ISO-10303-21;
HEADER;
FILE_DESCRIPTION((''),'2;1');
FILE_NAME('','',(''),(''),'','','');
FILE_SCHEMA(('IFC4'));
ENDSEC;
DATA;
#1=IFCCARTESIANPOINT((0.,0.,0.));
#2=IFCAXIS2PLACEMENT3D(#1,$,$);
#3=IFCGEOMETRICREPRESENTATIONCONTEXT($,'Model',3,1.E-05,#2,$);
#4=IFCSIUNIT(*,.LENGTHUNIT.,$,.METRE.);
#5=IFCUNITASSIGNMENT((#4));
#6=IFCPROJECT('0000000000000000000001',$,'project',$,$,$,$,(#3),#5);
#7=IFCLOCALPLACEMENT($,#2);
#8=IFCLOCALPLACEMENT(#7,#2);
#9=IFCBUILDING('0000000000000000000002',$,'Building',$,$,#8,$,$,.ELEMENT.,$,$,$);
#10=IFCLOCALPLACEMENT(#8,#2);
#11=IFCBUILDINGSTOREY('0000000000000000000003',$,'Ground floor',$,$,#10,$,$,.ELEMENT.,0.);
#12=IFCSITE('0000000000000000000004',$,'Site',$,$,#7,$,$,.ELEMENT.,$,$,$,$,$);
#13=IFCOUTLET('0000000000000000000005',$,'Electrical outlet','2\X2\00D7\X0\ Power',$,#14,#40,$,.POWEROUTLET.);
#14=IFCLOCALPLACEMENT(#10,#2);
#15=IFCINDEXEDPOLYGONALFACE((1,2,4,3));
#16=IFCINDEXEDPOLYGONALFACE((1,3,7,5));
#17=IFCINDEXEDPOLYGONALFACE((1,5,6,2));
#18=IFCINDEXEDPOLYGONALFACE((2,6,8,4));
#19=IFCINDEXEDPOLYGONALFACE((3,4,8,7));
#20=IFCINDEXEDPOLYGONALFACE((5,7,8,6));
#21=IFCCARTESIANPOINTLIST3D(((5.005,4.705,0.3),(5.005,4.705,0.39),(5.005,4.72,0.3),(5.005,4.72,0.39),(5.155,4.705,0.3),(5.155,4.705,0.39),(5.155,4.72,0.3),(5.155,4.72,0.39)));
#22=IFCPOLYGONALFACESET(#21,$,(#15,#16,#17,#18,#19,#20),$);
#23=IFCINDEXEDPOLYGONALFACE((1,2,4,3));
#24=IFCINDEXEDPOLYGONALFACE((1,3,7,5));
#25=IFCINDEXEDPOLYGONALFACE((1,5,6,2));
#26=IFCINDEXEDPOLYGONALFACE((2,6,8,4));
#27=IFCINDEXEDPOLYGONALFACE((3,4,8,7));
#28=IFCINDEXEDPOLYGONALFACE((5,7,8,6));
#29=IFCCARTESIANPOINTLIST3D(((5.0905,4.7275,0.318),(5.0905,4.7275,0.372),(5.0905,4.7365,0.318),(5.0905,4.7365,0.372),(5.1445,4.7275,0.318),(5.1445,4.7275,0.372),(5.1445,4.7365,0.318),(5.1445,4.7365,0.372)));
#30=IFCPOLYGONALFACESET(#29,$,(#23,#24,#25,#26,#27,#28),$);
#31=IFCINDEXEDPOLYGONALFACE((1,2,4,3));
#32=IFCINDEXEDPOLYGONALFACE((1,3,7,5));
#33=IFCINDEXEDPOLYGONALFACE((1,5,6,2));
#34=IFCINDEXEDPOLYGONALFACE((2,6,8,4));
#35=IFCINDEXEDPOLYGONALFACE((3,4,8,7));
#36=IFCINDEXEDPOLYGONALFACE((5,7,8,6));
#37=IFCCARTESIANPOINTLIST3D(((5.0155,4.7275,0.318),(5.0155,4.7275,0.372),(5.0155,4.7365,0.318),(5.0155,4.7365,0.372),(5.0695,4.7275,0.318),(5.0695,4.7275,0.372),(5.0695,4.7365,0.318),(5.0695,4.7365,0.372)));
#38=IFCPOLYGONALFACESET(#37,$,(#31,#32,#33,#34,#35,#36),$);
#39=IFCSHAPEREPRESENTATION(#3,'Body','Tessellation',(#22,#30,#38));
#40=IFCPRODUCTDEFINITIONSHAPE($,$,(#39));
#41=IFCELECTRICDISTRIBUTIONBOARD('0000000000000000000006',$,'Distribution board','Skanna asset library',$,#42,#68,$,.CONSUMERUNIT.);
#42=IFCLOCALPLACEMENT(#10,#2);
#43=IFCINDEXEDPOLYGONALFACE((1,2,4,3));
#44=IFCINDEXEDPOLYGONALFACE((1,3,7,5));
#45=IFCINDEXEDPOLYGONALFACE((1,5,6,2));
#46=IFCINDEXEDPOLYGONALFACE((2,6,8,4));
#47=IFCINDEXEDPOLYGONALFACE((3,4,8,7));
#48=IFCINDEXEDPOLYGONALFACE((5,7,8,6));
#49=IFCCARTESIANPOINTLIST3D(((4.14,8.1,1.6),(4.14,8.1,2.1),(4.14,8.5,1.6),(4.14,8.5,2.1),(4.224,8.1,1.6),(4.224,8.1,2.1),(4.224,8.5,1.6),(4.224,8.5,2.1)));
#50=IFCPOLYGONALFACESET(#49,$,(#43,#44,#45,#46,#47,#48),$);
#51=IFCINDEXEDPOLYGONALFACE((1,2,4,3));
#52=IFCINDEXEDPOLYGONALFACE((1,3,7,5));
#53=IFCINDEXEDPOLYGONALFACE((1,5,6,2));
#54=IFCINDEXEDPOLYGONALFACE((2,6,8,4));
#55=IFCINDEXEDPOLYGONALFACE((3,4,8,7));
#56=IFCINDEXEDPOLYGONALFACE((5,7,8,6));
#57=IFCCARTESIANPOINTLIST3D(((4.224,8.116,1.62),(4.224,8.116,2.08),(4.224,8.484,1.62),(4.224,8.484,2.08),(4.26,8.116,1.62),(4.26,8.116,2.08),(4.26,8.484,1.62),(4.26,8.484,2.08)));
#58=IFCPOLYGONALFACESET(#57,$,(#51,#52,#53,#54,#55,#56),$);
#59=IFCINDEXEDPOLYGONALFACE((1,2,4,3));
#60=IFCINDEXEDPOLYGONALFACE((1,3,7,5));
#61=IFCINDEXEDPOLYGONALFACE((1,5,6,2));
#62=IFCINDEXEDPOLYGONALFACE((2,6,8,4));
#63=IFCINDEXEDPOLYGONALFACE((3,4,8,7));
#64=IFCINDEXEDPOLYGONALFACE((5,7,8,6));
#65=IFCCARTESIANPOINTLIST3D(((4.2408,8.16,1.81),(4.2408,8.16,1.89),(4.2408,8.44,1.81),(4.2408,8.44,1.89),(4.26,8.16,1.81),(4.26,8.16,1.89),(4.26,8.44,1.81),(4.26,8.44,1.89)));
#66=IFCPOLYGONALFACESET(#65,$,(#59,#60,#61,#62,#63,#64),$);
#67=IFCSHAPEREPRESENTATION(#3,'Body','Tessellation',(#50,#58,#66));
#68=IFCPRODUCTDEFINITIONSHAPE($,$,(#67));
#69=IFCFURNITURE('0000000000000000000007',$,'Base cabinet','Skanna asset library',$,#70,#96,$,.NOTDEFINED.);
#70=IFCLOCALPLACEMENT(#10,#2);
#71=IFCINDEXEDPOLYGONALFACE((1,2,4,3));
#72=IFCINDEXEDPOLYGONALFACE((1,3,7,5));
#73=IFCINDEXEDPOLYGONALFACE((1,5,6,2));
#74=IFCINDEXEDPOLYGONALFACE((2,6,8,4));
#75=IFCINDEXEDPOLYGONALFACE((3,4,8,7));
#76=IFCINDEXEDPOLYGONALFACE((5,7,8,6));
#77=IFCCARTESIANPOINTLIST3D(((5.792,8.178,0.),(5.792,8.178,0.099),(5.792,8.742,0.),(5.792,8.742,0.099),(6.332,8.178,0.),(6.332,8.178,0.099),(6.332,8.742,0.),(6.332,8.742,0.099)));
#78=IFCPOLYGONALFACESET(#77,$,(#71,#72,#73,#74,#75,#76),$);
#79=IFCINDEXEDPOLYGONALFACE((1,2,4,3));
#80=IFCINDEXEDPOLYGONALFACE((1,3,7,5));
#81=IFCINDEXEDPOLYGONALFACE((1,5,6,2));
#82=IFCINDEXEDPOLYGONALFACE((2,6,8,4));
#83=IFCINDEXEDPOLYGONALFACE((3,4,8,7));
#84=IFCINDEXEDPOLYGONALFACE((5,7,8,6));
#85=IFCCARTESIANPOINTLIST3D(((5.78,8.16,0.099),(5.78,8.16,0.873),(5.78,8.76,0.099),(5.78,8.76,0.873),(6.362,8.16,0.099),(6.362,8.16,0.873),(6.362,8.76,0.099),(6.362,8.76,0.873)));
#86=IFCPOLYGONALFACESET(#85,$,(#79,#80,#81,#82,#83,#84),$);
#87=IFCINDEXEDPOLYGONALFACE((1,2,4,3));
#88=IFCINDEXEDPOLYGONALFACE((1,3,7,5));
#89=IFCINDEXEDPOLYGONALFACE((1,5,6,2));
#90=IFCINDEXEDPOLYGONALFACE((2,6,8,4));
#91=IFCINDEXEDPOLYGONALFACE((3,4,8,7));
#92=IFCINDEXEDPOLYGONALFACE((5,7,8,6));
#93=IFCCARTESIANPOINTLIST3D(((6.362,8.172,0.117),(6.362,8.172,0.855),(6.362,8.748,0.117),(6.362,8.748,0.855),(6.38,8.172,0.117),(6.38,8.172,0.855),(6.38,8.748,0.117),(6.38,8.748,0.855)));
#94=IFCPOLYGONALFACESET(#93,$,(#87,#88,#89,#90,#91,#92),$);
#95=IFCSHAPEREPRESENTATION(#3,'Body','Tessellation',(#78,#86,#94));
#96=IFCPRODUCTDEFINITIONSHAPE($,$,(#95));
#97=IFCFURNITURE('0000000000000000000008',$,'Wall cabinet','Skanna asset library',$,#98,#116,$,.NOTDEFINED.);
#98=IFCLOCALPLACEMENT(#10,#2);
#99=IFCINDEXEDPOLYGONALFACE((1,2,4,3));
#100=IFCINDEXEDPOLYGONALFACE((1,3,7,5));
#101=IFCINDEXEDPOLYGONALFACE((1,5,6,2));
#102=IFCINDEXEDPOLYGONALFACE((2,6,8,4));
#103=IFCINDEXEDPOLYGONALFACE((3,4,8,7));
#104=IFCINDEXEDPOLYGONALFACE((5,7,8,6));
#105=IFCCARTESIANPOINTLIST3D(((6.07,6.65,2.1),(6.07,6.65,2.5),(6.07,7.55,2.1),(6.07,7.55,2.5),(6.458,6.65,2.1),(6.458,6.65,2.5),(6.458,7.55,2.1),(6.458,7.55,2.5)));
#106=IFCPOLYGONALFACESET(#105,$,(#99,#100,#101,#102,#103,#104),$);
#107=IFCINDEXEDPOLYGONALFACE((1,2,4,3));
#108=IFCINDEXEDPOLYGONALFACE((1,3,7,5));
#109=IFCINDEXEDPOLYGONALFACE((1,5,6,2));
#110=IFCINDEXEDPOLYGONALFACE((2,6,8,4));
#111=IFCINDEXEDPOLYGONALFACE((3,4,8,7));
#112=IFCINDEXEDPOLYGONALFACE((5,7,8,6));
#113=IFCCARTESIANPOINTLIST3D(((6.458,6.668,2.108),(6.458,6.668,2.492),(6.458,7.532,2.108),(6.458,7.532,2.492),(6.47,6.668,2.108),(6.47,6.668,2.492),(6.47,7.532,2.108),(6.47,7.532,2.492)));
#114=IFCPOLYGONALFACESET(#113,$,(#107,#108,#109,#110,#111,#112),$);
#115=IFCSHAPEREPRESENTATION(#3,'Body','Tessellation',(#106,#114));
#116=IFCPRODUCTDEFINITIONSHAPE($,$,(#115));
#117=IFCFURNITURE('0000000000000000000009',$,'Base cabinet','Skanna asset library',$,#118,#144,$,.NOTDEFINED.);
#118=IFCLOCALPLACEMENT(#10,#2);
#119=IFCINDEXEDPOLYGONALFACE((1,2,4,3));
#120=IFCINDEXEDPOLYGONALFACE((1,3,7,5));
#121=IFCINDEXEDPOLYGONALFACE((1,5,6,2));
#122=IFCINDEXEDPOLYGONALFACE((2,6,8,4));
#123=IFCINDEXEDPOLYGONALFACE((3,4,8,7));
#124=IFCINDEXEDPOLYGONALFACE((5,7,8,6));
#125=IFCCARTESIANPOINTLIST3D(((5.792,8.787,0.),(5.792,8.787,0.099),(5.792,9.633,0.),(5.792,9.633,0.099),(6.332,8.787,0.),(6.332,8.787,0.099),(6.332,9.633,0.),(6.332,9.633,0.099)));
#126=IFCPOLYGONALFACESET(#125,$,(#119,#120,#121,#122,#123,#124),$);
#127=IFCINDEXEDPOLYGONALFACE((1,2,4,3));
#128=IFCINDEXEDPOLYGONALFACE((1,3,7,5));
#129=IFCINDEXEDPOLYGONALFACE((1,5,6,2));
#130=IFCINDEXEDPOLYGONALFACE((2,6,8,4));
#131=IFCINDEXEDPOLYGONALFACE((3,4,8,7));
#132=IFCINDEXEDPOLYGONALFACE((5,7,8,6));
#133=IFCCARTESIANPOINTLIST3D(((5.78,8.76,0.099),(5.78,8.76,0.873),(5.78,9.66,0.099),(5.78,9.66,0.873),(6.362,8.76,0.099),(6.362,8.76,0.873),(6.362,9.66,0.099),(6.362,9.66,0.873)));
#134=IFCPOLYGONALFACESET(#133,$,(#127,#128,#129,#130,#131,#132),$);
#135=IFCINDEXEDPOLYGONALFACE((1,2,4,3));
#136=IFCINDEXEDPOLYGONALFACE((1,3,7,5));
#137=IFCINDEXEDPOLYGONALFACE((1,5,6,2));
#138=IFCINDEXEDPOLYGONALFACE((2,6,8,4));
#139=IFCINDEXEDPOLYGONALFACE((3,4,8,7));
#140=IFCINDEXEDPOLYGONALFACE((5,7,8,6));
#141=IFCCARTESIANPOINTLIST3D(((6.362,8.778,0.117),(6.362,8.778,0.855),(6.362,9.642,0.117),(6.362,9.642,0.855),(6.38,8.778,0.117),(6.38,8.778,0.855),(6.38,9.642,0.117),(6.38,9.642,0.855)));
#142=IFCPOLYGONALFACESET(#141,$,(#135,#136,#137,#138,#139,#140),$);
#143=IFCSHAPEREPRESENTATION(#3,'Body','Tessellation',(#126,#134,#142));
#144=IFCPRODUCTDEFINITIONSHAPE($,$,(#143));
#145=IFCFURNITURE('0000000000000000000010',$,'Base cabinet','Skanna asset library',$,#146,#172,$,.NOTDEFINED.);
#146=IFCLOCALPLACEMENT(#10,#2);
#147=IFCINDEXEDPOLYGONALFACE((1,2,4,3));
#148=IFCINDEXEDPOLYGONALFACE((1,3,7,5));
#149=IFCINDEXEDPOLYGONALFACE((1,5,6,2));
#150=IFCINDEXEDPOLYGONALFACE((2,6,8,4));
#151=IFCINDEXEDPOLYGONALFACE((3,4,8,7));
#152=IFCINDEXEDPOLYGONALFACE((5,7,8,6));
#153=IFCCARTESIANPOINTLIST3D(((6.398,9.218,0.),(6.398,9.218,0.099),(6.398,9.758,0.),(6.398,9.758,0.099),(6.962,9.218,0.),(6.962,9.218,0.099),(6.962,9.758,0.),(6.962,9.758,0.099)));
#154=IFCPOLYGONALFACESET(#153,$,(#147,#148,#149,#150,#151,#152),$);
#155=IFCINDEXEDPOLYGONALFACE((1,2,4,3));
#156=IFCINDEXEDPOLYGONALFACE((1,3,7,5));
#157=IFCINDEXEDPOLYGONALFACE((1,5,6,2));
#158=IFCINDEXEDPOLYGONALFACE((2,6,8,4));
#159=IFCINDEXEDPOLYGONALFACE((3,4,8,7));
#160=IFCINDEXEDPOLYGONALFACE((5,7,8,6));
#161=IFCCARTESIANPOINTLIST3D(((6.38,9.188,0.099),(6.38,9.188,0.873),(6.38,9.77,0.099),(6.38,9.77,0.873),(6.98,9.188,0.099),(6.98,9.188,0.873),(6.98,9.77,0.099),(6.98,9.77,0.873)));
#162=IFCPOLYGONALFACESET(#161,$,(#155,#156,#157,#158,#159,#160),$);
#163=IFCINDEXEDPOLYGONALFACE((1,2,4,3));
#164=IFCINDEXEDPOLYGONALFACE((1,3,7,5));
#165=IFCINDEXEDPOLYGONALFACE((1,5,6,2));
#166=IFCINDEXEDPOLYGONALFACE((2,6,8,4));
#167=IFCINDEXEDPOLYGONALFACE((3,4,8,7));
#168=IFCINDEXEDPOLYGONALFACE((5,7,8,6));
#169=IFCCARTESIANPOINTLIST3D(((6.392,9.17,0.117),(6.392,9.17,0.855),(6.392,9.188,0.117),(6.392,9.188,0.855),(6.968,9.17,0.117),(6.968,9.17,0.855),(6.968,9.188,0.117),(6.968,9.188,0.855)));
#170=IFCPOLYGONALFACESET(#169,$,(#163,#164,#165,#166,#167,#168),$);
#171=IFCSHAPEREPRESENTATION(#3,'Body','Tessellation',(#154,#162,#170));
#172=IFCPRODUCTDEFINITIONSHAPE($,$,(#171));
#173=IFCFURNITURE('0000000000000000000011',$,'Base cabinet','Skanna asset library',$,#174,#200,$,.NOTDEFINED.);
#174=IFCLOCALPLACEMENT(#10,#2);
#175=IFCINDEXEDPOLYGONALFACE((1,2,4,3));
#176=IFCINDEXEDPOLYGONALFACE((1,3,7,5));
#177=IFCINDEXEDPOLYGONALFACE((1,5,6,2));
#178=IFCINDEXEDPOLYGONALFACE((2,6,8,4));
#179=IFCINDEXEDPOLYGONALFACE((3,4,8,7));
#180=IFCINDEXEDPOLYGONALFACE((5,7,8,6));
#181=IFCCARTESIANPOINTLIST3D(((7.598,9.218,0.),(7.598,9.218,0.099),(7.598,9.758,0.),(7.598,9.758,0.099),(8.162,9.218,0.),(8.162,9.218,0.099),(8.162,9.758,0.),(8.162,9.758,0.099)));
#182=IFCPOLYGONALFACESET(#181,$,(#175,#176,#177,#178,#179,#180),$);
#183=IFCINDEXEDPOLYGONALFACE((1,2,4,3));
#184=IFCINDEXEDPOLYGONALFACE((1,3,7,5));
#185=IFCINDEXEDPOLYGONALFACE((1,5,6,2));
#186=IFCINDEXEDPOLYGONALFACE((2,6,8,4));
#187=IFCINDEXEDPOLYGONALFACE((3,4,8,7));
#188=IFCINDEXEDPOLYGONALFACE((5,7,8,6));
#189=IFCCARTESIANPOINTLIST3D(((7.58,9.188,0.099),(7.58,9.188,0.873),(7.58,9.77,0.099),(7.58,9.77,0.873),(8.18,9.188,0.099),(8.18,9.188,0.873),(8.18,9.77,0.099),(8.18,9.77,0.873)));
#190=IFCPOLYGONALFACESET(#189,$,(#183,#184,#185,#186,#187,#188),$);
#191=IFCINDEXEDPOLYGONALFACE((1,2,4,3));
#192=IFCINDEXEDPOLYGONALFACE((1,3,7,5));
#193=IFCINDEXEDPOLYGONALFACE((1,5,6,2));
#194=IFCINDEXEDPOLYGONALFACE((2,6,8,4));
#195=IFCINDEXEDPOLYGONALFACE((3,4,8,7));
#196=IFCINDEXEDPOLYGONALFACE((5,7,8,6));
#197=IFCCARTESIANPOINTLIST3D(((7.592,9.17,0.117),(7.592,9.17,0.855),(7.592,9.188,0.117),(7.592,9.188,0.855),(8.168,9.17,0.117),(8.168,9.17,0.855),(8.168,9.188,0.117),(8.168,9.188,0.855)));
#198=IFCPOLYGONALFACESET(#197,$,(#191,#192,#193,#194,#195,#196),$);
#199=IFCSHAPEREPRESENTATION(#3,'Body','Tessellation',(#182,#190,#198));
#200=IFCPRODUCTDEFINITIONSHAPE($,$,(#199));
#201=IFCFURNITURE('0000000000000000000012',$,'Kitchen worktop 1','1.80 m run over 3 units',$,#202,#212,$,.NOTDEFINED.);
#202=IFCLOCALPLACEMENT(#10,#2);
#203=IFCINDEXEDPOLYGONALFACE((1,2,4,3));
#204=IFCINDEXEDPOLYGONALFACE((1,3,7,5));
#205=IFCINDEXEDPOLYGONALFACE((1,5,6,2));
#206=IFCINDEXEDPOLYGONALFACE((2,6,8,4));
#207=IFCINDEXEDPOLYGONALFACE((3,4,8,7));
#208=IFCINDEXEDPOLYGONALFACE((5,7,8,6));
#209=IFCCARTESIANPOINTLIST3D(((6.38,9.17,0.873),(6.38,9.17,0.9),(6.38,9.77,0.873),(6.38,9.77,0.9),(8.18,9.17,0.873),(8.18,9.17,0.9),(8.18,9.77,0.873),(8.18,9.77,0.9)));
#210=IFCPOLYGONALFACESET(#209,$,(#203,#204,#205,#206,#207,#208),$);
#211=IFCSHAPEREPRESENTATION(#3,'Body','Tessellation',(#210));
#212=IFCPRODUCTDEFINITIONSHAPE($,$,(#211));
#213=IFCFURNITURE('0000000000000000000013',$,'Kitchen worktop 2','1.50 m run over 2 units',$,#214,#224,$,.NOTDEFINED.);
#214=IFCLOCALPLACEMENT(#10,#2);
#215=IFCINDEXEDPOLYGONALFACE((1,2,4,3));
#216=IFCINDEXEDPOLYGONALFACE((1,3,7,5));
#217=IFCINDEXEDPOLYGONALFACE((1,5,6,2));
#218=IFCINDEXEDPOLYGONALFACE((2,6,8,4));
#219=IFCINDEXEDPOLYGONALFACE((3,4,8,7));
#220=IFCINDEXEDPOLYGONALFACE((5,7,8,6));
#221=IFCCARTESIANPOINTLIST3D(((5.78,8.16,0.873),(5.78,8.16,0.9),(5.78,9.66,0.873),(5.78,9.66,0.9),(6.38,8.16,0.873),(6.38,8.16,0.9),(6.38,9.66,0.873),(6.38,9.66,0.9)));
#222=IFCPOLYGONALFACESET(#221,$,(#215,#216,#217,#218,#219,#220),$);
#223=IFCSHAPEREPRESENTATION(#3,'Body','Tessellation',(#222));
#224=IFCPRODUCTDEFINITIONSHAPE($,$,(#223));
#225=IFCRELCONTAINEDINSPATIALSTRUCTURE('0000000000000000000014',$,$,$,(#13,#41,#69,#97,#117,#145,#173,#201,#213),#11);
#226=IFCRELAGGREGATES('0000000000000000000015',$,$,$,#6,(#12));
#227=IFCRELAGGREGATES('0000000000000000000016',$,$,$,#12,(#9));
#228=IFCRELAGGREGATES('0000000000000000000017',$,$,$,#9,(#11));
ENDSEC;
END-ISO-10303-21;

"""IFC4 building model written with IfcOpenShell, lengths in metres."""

from ifc_helpers import new_model, si_unit, frame, frame_2d, origin, origin_2d, place, context, project, spatial, rectangle, extrude, element, save


model = new_model("IFC4")

# Units and contexts
model_context = context("Model", 3, precision=1e-05, world=origin())
ifc_project = project(units=[si_unit("LENGTHUNIT", "METRE")], contexts=[model_context])

# Site, building, storey
site_placement = place(None, origin())
site = spatial("IfcSite", under=ifc_project, at=site_placement, Name="Site", CompositionType="ELEMENT")
building_placement = place(site_placement, origin())
building = spatial("IfcBuilding", under=site, at=building_placement, Name="Building", CompositionType="ELEMENT")
storey_placement = place(building_placement, origin())
storey = spatial("IfcBuildingStorey", under=building, at=storey_placement, Name="Ground floor", CompositionType="ELEMENT", Elevation=0.0)

# Outlet
outlet_placement = place(storey_placement, frame((5.08, 4.72, 0.3), z_axis=(0.0, 0.0, 1.0), x_axis=(-1.0, 0.0, 0.0)))
element("IfcOutlet", 1, at=outlet_placement, inside=storey, Name="Electrical outlet", Description="2× Power", PredefinedType="POWEROUTLET", context=model_context, shape_type="SweptSolid", body=[
    extrude(rectangle(XDim=0.15, YDim=0.015, at=frame_2d((0.0, 0.0075))), origin(), (0.0, 0.0, 1.0), 0.09),
    extrude(rectangle(XDim=0.054, YDim=0.009, at=frame_2d((-0.0375, -0.012))), frame((0.0, 0.0, 0.018)), (0.0, 0.0, 1.0), 0.054),
    extrude(rectangle(XDim=0.054, YDim=0.009, at=frame_2d((0.0375, -0.012))), frame((0.0, 0.0, 0.018)), (0.0, 0.0, 1.0), 0.054),
])

# Electric distribution board
electric_distribution_board_placement = place(storey_placement, frame((4.2, 8.3, 1.6), z_axis=(0.0, 0.0, 1.0), x_axis=(0.0, 1.0, 0.0)))
element("IfcElectricDistributionBoard", 2, at=electric_distribution_board_placement, inside=storey, Name="Distribution board", Description="Skanna asset library", PredefinedType="CONSUMERUNIT", context=model_context, shape_type="SweptSolid", body=[
    extrude(rectangle(XDim=0.4, YDim=0.084, at=frame_2d((0.0, 0.018))), origin(), (0.0, 0.0, 1.0), 0.5),
    extrude(rectangle(XDim=0.368, YDim=0.036, at=frame_2d((0.0, -0.042))), frame((0.0, 0.0, 0.02)), (0.0, 0.0, 1.0), 0.46),
    extrude(rectangle(XDim=0.28, YDim=0.0192, at=frame_2d((0.0, -0.0504))), frame((0.0, 0.0, 0.21)), (0.0, 0.0, 1.0), 0.08),
])

# Furniture
furniture_1_placement = place(storey_placement, frame((6.08, 8.46, 0.0), z_axis=(0.0, 0.0, 1.0), x_axis=(0.0, 1.0, 0.0)))
element("IfcFurniture", 3, at=furniture_1_placement, inside=storey, Name="Base cabinet", Description="Skanna asset library", PredefinedType="NOTDEFINED", context=model_context, shape_type="SweptSolid", body=[
    extrude(rectangle(XDim=0.564, YDim=0.54, at=frame_2d((0.0, 0.018))), origin(), (0.0, 0.0, 1.0), 0.099),
    extrude(rectangle(XDim=0.6, YDim=0.582, at=frame_2d((0.0, 0.009))), frame((0.0, 0.0, 0.099)), (0.0, 0.0, 1.0), 0.774),
    extrude(rectangle(XDim=0.576, YDim=0.018, at=frame_2d((0.0, -0.291))), frame((0.0, 0.0, 0.117)), (0.0, 0.0, 1.0), 0.738),
])
furniture_2_placement = place(storey_placement, frame((6.27, 7.1, 2.1), z_axis=(0.0, 0.0, 1.0), x_axis=(0.0, 1.0, 0.0)))
element("IfcFurniture", 4, at=furniture_2_placement, inside=storey, Name="Wall cabinet", Description="Skanna asset library", PredefinedType="NOTDEFINED", context=model_context, shape_type="SweptSolid", body=[
    extrude(rectangle(XDim=0.9, YDim=0.388, at=frame_2d((0.0, 0.006))), origin(), (0.0, 0.0, 1.0), 0.4),
    extrude(rectangle(XDim=0.864, YDim=0.012, at=frame_2d((0.0, -0.194))), frame((0.0, 0.0, 0.008)), (0.0, 0.0, 1.0), 0.384),
])
furniture_3_placement = place(storey_placement, frame((6.08, 9.21, 0.0), z_axis=(0.0, 0.0, 1.0), x_axis=(0.0, 1.0, 0.0)))
element("IfcFurniture", 5, at=furniture_3_placement, inside=storey, Name="Base cabinet", Description="Skanna asset library", PredefinedType="NOTDEFINED", context=model_context, shape_type="SweptSolid", body=[
    extrude(rectangle(XDim=0.846, YDim=0.54, at=frame_2d((0.0, 0.018))), origin(), (0.0, 0.0, 1.0), 0.099),
    extrude(rectangle(XDim=0.9, YDim=0.582, at=frame_2d((0.0, 0.009))), frame((0.0, 0.0, 0.099)), (0.0, 0.0, 1.0), 0.774),
    extrude(rectangle(XDim=0.864, YDim=0.018, at=frame_2d((0.0, -0.291))), frame((0.0, 0.0, 0.117)), (0.0, 0.0, 1.0), 0.738),
])
for number, where, z_axis, x_axis, name in (
    (6, (6.68, 9.47, 0.0), (0.0, 0.0, 1.0), (1.0, 0.0, 0.0), "Base cabinet"),
    (7, (7.88, 9.47, 0.0), (0.0, 0.0, 1.0), (1.0, 0.0, 0.0), "Base cabinet"),
):
    element("IfcFurniture", number, at=place(storey_placement, frame(where, z_axis=z_axis, x_axis=x_axis)), inside=storey, Name=name, Description="Skanna asset library", PredefinedType="NOTDEFINED", context=model_context, shape_type="SweptSolid", body=[
        extrude(rectangle(XDim=0.564, YDim=0.54, at=frame_2d((0.0, 0.018))), origin(), (0.0, 0.0, 1.0), 0.099),
        extrude(rectangle(XDim=0.6, YDim=0.582, at=frame_2d((0.0, 0.009))), frame((0.0, 0.0, 0.099)), (0.0, 0.0, 1.0), 0.774),
        extrude(rectangle(XDim=0.576, YDim=0.018, at=frame_2d((0.0, -0.291))), frame((0.0, 0.0, 0.117)), (0.0, 0.0, 1.0), 0.738),
    ])
furniture_4_placement = place(storey_placement, frame((7.28, 9.47, 0.873), z_axis=(0.0, 0.0, 1.0), x_axis=(1.0, 0.0, 0.0)))
element("IfcFurniture", 8, at=furniture_4_placement, inside=storey, Name="Kitchen worktop 1", Description="1.80 m run over 3 units", PredefinedType="NOTDEFINED", context=model_context, shape_type="SweptSolid", body=[
    extrude(rectangle(XDim=1.8, YDim=0.6, at=origin_2d()), origin(), (0.0, 0.0, 1.0), 0.027),
])
furniture_5_placement = place(storey_placement, frame((6.08, 8.91, 0.873), z_axis=(0.0, 0.0, 1.0), x_axis=(0.0, 1.0, 0.0)))
element("IfcFurniture", 9, at=furniture_5_placement, inside=storey, Name="Kitchen worktop 2", Description="1.50 m run over 2 units", PredefinedType="NOTDEFINED", context=model_context, shape_type="SweptSolid", body=[
    extrude(rectangle(XDim=1.5, YDim=0.6, at=origin_2d()), origin(), (0.0, 0.0, 1.0), 0.027),
])

save(model, "model.ifc")
